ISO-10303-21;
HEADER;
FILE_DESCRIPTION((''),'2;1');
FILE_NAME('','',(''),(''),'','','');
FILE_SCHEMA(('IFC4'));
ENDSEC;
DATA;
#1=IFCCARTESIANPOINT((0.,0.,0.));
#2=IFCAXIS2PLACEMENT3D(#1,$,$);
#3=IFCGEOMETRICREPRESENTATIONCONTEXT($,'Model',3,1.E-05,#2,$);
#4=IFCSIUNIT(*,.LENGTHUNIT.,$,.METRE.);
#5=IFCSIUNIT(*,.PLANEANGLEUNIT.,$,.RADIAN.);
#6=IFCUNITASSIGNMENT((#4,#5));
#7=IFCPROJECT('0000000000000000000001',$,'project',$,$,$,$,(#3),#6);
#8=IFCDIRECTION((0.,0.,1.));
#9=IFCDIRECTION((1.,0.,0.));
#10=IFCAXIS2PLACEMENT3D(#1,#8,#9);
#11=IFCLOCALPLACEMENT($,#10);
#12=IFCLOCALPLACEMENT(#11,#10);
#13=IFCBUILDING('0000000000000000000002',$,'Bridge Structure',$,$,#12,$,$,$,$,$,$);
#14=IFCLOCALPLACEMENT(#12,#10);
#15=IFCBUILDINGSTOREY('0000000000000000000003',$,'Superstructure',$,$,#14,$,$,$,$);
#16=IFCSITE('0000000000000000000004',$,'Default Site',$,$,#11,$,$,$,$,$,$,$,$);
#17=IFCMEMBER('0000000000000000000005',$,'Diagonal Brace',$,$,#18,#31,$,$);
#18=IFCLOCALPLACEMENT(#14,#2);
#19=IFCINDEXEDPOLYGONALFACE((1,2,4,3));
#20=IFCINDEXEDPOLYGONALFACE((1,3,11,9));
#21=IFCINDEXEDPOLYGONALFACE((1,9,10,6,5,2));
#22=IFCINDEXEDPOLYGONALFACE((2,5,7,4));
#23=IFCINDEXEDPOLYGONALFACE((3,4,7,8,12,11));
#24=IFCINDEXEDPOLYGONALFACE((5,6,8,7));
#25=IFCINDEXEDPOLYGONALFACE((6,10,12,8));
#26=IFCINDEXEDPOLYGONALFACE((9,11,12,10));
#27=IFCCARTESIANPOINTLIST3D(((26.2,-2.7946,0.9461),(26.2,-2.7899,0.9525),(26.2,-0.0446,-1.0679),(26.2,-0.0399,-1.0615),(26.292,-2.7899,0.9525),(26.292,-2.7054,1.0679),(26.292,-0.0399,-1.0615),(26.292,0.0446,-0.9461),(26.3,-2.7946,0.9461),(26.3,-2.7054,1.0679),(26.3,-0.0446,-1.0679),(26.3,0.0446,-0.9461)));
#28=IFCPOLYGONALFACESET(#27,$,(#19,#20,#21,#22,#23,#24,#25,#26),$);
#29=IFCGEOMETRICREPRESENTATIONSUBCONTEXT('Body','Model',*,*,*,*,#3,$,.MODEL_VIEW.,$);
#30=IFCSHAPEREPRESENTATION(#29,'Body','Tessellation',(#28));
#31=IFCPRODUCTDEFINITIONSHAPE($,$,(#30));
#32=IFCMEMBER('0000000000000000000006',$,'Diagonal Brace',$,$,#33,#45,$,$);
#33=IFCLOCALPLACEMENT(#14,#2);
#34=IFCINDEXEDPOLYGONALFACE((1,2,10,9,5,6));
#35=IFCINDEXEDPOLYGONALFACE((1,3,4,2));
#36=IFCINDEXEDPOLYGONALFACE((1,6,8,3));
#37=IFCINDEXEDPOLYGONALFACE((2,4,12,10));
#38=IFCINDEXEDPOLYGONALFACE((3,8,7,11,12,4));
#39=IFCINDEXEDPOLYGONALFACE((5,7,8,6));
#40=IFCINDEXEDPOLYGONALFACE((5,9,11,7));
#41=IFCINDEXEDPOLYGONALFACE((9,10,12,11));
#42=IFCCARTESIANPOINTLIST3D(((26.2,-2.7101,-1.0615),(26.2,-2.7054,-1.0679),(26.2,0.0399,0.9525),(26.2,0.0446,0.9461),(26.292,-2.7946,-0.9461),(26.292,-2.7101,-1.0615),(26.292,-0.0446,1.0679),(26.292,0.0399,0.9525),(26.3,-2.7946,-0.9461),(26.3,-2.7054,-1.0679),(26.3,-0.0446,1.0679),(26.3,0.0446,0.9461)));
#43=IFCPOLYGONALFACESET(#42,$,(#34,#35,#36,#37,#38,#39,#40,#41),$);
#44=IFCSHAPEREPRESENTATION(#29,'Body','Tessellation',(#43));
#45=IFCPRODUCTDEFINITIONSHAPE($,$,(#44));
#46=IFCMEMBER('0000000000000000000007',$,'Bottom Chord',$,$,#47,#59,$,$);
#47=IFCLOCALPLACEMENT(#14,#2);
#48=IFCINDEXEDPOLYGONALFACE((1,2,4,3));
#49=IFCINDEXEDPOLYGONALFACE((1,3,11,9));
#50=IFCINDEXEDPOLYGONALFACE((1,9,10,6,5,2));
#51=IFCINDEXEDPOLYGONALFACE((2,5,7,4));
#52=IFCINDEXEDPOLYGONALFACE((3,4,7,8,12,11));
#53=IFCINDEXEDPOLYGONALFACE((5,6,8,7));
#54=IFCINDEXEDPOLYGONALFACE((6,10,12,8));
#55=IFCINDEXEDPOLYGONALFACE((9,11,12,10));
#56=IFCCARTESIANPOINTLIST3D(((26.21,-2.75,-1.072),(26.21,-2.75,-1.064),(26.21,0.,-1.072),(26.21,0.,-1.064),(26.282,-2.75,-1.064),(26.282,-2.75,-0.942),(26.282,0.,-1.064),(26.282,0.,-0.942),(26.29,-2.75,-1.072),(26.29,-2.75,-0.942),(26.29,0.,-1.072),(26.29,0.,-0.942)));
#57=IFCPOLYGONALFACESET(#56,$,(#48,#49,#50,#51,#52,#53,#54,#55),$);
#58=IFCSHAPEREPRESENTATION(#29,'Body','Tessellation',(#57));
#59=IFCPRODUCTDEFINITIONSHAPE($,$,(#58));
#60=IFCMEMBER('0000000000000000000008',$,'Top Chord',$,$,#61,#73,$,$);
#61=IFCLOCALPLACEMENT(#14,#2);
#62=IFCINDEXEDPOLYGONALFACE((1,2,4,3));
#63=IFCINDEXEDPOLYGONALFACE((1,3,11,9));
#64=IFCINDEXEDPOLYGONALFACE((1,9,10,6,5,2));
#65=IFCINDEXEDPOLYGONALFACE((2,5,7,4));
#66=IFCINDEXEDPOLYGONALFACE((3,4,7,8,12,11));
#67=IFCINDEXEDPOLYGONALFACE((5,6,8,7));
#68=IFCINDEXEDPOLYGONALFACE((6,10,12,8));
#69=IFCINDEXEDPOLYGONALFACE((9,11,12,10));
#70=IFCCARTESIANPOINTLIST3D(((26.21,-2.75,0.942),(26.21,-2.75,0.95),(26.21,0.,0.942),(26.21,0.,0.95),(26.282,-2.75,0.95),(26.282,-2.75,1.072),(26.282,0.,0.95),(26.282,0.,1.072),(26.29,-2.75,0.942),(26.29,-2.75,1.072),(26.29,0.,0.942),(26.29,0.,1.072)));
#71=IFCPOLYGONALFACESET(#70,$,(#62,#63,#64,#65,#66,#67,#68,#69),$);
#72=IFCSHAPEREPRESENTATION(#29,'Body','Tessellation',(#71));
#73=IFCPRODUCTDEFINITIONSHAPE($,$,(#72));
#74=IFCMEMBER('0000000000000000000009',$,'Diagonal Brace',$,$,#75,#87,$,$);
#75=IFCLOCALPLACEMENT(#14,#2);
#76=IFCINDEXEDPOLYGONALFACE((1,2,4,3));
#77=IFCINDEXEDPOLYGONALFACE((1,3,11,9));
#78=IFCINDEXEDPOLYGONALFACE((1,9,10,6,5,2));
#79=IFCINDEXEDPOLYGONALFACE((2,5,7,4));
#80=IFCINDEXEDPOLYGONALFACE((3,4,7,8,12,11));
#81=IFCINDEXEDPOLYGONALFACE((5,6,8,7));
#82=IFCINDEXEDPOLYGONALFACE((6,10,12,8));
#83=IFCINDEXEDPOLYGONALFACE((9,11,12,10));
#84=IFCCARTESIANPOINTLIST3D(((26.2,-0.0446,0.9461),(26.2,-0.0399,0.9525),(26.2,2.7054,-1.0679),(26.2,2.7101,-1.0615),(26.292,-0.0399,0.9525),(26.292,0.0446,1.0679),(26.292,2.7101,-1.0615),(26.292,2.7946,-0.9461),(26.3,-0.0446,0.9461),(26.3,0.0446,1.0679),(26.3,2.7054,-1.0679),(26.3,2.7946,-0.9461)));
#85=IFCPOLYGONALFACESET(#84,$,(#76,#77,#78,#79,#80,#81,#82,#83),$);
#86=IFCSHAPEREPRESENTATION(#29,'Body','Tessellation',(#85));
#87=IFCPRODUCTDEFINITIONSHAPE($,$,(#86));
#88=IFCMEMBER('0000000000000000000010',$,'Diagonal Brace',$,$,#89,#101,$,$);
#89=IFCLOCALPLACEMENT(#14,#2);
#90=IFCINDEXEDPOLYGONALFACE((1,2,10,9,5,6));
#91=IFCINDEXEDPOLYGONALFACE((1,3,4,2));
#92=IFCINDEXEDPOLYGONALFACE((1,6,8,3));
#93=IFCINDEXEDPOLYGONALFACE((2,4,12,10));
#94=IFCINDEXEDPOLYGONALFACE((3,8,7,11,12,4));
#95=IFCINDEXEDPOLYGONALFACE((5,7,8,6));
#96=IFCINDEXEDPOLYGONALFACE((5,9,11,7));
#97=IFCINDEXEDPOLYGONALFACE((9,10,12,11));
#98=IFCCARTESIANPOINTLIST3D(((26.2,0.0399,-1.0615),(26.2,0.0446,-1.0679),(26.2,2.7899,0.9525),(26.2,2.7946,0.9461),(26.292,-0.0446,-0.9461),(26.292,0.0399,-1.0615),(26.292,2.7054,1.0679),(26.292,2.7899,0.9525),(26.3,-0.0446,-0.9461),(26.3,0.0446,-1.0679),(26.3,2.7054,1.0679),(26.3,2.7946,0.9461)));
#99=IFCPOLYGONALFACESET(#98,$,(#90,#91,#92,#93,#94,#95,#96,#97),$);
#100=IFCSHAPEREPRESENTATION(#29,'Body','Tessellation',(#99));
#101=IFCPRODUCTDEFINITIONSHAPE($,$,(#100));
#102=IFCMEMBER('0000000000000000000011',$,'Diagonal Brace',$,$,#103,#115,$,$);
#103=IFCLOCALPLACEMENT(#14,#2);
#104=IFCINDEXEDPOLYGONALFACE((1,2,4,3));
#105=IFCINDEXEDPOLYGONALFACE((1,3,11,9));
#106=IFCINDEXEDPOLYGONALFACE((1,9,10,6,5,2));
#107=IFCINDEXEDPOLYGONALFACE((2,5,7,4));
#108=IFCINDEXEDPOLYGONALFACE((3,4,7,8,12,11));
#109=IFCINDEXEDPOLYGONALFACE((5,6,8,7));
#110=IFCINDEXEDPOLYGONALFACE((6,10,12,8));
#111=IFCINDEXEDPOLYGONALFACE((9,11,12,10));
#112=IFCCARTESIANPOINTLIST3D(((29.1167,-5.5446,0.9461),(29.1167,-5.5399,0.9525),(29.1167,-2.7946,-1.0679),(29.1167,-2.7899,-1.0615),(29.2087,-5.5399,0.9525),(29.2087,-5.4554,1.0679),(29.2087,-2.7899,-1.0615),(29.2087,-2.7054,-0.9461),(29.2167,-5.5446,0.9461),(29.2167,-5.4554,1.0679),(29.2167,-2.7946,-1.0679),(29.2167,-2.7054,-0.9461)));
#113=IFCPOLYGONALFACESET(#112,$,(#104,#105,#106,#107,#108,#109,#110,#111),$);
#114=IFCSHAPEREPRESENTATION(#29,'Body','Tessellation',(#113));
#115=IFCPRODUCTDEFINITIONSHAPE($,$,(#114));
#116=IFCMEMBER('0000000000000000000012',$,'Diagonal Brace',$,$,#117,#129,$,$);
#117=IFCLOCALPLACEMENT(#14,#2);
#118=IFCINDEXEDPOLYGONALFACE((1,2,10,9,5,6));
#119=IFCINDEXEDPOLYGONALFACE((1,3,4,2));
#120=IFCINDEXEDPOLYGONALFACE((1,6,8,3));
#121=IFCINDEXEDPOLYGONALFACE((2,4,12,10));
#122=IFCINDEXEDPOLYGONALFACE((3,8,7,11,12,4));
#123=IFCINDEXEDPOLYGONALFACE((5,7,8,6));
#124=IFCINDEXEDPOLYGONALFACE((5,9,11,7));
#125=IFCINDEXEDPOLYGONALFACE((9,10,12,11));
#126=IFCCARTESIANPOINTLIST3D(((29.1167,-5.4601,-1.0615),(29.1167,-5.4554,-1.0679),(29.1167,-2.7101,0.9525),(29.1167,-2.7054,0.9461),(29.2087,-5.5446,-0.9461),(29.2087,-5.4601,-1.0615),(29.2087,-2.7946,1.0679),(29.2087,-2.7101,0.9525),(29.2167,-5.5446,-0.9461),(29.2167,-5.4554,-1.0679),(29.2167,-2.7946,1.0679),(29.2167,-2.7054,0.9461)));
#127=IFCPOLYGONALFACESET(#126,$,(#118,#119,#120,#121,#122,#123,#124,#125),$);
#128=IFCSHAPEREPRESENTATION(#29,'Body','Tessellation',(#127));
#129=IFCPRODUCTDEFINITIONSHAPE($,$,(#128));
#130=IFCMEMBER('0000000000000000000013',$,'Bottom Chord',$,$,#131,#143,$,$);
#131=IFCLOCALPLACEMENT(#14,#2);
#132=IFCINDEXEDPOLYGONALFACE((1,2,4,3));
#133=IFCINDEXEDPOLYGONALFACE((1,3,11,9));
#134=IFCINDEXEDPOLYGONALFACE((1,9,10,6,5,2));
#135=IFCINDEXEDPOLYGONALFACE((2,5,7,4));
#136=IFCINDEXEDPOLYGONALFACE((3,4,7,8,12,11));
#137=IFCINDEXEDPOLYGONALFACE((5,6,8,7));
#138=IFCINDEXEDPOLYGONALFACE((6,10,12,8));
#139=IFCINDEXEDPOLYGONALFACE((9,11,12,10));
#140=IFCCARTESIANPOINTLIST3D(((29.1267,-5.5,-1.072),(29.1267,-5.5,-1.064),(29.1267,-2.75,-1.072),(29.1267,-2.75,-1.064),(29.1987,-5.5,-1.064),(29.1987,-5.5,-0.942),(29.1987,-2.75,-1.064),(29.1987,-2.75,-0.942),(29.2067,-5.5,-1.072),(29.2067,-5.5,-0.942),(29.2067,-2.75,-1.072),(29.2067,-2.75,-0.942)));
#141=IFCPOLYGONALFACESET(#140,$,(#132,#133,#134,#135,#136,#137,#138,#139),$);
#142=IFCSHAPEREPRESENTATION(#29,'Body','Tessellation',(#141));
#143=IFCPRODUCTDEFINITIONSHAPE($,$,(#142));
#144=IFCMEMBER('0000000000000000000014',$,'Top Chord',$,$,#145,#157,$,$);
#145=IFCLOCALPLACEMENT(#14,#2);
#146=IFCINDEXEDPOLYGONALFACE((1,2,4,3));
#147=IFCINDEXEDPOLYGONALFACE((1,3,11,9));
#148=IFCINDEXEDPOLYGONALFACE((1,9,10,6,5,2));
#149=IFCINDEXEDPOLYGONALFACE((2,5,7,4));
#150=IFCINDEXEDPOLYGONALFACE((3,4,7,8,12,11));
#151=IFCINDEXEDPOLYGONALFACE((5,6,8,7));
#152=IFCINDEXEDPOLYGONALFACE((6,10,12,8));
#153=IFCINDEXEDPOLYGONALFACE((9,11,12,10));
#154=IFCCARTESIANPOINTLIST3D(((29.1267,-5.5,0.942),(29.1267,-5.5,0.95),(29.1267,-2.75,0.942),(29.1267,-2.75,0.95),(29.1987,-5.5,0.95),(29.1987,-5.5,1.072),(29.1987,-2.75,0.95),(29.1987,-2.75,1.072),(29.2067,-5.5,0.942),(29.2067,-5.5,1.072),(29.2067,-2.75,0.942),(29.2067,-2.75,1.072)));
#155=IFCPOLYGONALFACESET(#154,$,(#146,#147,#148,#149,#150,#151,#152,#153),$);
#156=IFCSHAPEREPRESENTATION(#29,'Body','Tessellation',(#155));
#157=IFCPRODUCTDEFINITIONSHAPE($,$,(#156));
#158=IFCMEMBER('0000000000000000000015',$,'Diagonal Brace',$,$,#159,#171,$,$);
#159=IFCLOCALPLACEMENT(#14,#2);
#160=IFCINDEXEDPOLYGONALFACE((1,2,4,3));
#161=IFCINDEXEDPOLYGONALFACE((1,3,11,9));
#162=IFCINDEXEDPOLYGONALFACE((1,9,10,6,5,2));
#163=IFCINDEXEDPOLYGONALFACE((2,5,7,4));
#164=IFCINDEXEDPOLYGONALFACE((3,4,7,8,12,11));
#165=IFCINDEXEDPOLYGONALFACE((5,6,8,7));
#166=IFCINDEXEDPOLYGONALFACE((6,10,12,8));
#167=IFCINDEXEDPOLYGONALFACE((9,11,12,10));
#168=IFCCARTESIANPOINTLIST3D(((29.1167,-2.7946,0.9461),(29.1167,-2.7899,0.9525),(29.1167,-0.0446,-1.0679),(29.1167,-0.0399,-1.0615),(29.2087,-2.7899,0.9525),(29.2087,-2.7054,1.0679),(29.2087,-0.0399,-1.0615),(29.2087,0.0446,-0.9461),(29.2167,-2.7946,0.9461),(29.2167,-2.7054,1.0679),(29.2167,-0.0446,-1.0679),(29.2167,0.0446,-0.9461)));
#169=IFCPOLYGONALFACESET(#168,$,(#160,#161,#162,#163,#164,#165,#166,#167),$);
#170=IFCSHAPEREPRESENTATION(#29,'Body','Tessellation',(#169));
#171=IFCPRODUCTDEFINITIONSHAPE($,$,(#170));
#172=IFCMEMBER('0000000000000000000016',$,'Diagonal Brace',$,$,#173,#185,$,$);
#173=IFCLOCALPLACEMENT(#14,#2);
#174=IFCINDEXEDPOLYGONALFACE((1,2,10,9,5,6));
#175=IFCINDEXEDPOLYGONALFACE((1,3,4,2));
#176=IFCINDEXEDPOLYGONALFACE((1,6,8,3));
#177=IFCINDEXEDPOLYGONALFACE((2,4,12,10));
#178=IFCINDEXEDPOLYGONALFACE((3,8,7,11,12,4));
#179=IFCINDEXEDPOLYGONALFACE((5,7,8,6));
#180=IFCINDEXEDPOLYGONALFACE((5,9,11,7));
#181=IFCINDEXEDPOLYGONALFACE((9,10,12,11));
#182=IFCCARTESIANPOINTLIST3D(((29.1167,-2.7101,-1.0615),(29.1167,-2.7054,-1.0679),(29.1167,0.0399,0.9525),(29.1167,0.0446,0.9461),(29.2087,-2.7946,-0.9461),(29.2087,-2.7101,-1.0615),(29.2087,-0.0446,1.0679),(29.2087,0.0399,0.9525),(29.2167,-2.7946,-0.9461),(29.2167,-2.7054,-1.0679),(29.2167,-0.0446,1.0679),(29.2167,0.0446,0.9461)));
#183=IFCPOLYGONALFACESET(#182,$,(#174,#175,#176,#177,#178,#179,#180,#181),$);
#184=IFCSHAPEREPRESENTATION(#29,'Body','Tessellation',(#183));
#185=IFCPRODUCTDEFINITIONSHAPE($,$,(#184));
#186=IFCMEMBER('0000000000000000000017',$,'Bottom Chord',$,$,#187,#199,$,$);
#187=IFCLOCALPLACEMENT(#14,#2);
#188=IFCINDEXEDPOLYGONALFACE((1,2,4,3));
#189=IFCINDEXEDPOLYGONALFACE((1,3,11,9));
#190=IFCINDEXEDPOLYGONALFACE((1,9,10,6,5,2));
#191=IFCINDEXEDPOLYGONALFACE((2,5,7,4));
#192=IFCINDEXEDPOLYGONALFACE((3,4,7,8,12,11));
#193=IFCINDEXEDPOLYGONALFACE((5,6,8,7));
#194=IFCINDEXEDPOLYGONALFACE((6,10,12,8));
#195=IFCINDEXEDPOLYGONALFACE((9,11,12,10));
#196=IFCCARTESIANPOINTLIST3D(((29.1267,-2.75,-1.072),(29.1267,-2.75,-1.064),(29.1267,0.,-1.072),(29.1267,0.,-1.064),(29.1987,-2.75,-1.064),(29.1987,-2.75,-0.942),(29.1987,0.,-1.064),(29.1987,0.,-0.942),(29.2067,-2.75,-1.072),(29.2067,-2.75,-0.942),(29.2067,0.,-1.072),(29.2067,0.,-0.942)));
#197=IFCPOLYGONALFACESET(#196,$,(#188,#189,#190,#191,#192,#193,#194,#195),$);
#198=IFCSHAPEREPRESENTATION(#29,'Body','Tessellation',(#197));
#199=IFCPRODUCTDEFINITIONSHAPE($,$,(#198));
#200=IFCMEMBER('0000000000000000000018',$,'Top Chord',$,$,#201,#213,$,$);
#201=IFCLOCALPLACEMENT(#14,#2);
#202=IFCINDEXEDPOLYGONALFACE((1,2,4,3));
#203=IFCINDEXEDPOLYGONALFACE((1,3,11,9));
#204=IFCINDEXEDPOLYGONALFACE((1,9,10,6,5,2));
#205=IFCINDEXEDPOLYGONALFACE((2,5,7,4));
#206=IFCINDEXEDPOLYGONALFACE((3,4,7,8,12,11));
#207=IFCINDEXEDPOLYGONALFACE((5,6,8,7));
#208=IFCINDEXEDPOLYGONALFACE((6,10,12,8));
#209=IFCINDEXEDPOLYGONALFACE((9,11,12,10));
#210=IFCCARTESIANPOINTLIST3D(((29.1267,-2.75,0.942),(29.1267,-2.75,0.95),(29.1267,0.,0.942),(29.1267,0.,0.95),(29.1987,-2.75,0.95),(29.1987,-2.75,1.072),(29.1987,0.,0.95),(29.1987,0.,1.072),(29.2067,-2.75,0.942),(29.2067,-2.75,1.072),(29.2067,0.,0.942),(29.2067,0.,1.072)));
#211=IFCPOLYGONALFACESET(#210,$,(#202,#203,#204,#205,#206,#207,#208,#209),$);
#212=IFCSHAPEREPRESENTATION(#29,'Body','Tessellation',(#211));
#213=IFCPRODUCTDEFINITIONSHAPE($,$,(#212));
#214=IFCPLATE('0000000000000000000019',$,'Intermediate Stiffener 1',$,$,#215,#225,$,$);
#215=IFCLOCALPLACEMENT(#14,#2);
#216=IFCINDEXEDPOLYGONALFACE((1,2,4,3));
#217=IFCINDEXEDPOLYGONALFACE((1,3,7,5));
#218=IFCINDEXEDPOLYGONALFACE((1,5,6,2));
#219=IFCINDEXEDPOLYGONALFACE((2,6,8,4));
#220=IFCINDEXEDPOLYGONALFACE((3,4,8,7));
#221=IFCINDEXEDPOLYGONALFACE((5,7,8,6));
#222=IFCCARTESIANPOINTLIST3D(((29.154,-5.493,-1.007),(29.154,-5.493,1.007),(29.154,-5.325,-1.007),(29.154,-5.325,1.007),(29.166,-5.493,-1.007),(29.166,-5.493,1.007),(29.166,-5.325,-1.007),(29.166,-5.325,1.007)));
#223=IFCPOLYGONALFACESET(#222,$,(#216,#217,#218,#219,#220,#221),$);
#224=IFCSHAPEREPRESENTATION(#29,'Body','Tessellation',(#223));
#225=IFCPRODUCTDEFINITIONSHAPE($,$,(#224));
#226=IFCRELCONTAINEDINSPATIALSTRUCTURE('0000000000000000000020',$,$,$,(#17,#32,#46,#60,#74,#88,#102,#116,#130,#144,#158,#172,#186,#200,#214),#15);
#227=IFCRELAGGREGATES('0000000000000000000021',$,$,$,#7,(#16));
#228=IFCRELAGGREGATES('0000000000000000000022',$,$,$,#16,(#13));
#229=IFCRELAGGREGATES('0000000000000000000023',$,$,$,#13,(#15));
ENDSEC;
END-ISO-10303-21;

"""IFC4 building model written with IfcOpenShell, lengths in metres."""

from ifc_helpers import new_model, si_unit, frame, origin, origin_with_axes, origin_2d_with_axis, place, context, subcontext, project, spatial, rectangle, l_section, extrude, element, save


model = new_model("IFC4")

# Units and contexts
model_context = context("Model", 3, precision=1e-05, world=origin())
body_context = subcontext(model_context, "Body", "Model", "MODEL_VIEW")
ifc_project = project(units=[si_unit("LENGTHUNIT", "METRE"), si_unit("PLANEANGLEUNIT", "RADIAN")], contexts=[model_context])

# Site, building, storey
site_placement = place(None, origin_with_axes())
site = spatial("IfcSite", under=ifc_project, at=site_placement, Name="Default Site")
building_placement = place(site_placement, origin_with_axes())
building = spatial("IfcBuilding", under=site, at=building_placement, Name="Bridge Structure")
storey_placement = place(building_placement, origin_with_axes())
storey = spatial("IfcBuildingStorey", under=building, at=storey_placement, Name="Superstructure")

# Members
for number, where, z_axis, x_axis, name in (
    (1, (26.25, -2.75, 1.007), (0.0, 0.806778, -0.590855), (-1.0, 0.0, 0.0), "Diagonal Brace"),
    (2, (26.25, -2.75, -1.007), (0.0, 0.806778, 0.590855), (-1.0, 0.0, 0.0), "Diagonal Brace"),
):
    element("IfcMember", number, at=place(storey_placement, frame(where, z_axis=z_axis, x_axis=x_axis)), inside=storey, Name=name, context=body_context, shape_type="SweptSolid", body=[
        extrude(l_section(Depth=0.151, Width=0.1, Thickness=0.008, at=origin_2d_with_axis()), origin_with_axes(), (0.0, 0.0, 1.0), 3.4086),
    ])
for number, where, z_axis, x_axis, name in (
    (3, (26.25, -2.75, -1.007), (0.0, 1.0, 0.0), (-1.0, 0.0, 0.0), "Bottom Chord"),
    (4, (26.25, -2.75, 1.007), (0.0, 1.0, 0.0), (-1.0, 0.0, 0.0), "Top Chord"),
):
    element("IfcMember", number, at=place(storey_placement, frame(where, z_axis=z_axis, x_axis=x_axis)), inside=storey, Name=name, context=body_context, shape_type="SweptSolid", body=[
        extrude(l_section(Depth=0.13, Width=0.08, Thickness=0.008, at=origin_2d_with_axis()), origin_with_axes(), (0.0, 0.0, 1.0), 2.75),
    ])
for number, where, z_axis, x_axis, name in (
    (5, (26.25, 0.0, 1.007), (0.0, 0.806778, -0.590855), (-1.0, 0.0, 0.0), "Diagonal Brace"),
    (6, (26.25, 0.0, -1.007), (0.0, 0.806778, 0.590855), (-1.0, 0.0, 0.0), "Diagonal Brace"),
    (7, (29.1667, -5.5, 1.007), (0.0, 0.806778, -0.590855), (-1.0, 0.0, 0.0), "Diagonal Brace"),
    (8, (29.1667, -5.5, -1.007), (0.0, 0.806778, 0.590855), (-1.0, 0.0, 0.0), "Diagonal Brace"),
):
    element("IfcMember", number, at=place(storey_placement, frame(where, z_axis=z_axis, x_axis=x_axis)), inside=storey, Name=name, context=body_context, shape_type="SweptSolid", body=[
        extrude(l_section(Depth=0.151, Width=0.1, Thickness=0.008, at=origin_2d_with_axis()), origin_with_axes(), (0.0, 0.0, 1.0), 3.4086),
    ])
for number, where, z_axis, x_axis, name in (
    (9, (29.1667, -5.5, -1.007), (0.0, 1.0, 0.0), (-1.0, 0.0, 0.0), "Bottom Chord"),
    (10, (29.1667, -5.5, 1.007), (0.0, 1.0, 0.0), (-1.0, 0.0, 0.0), "Top Chord"),
):
    element("IfcMember", number, at=place(storey_placement, frame(where, z_axis=z_axis, x_axis=x_axis)), inside=storey, Name=name, context=body_context, shape_type="SweptSolid", body=[
        extrude(l_section(Depth=0.13, Width=0.08, Thickness=0.008, at=origin_2d_with_axis()), origin_with_axes(), (0.0, 0.0, 1.0), 2.75),
    ])
for number, where, z_axis, x_axis, name in (
    (11, (29.1667, -2.75, 1.007), (0.0, 0.806778, -0.590855), (-1.0, 0.0, 0.0), "Diagonal Brace"),
    (12, (29.1667, -2.75, -1.007), (0.0, 0.806778, 0.590855), (-1.0, 0.0, 0.0), "Diagonal Brace"),
):
    element("IfcMember", number, at=place(storey_placement, frame(where, z_axis=z_axis, x_axis=x_axis)), inside=storey, Name=name, context=body_context, shape_type="SweptSolid", body=[
        extrude(l_section(Depth=0.151, Width=0.1, Thickness=0.008, at=origin_2d_with_axis()), origin_with_axes(), (0.0, 0.0, 1.0), 3.4086),
    ])
for number, where, z_axis, x_axis, name in (
    (13, (29.1667, -2.75, -1.007), (0.0, 1.0, 0.0), (-1.0, 0.0, 0.0), "Bottom Chord"),
    (14, (29.1667, -2.75, 1.007), (0.0, 1.0, 0.0), (-1.0, 0.0, 0.0), "Top Chord"),
):
    element("IfcMember", number, at=place(storey_placement, frame(where, z_axis=z_axis, x_axis=x_axis)), inside=storey, Name=name, context=body_context, shape_type="SweptSolid", body=[
        extrude(l_section(Depth=0.13, Width=0.08, Thickness=0.008, at=origin_2d_with_axis()), origin_with_axes(), (0.0, 0.0, 1.0), 2.75),
    ])

# Plate
for number, where, z_axis, x_axis, name in (
    (15, (29.16, -5.409, -1.007), (0.0, 0.0, 1.0), (1.0, 0.0, 0.0), "Intermediate Stiffener 1"),
):
    element("IfcPlate", number, at=place(storey_placement, frame(where, z_axis=z_axis, x_axis=x_axis)), inside=storey, Name=name, context=body_context, shape_type="SweptSolid", body=[
        extrude(rectangle(XDim=0.012, YDim=0.168, at=origin_2d_with_axis()), origin_with_axes(), (0.0, 0.0, 1.0), 2.014),
    ])

save(model, "model.ifc")
